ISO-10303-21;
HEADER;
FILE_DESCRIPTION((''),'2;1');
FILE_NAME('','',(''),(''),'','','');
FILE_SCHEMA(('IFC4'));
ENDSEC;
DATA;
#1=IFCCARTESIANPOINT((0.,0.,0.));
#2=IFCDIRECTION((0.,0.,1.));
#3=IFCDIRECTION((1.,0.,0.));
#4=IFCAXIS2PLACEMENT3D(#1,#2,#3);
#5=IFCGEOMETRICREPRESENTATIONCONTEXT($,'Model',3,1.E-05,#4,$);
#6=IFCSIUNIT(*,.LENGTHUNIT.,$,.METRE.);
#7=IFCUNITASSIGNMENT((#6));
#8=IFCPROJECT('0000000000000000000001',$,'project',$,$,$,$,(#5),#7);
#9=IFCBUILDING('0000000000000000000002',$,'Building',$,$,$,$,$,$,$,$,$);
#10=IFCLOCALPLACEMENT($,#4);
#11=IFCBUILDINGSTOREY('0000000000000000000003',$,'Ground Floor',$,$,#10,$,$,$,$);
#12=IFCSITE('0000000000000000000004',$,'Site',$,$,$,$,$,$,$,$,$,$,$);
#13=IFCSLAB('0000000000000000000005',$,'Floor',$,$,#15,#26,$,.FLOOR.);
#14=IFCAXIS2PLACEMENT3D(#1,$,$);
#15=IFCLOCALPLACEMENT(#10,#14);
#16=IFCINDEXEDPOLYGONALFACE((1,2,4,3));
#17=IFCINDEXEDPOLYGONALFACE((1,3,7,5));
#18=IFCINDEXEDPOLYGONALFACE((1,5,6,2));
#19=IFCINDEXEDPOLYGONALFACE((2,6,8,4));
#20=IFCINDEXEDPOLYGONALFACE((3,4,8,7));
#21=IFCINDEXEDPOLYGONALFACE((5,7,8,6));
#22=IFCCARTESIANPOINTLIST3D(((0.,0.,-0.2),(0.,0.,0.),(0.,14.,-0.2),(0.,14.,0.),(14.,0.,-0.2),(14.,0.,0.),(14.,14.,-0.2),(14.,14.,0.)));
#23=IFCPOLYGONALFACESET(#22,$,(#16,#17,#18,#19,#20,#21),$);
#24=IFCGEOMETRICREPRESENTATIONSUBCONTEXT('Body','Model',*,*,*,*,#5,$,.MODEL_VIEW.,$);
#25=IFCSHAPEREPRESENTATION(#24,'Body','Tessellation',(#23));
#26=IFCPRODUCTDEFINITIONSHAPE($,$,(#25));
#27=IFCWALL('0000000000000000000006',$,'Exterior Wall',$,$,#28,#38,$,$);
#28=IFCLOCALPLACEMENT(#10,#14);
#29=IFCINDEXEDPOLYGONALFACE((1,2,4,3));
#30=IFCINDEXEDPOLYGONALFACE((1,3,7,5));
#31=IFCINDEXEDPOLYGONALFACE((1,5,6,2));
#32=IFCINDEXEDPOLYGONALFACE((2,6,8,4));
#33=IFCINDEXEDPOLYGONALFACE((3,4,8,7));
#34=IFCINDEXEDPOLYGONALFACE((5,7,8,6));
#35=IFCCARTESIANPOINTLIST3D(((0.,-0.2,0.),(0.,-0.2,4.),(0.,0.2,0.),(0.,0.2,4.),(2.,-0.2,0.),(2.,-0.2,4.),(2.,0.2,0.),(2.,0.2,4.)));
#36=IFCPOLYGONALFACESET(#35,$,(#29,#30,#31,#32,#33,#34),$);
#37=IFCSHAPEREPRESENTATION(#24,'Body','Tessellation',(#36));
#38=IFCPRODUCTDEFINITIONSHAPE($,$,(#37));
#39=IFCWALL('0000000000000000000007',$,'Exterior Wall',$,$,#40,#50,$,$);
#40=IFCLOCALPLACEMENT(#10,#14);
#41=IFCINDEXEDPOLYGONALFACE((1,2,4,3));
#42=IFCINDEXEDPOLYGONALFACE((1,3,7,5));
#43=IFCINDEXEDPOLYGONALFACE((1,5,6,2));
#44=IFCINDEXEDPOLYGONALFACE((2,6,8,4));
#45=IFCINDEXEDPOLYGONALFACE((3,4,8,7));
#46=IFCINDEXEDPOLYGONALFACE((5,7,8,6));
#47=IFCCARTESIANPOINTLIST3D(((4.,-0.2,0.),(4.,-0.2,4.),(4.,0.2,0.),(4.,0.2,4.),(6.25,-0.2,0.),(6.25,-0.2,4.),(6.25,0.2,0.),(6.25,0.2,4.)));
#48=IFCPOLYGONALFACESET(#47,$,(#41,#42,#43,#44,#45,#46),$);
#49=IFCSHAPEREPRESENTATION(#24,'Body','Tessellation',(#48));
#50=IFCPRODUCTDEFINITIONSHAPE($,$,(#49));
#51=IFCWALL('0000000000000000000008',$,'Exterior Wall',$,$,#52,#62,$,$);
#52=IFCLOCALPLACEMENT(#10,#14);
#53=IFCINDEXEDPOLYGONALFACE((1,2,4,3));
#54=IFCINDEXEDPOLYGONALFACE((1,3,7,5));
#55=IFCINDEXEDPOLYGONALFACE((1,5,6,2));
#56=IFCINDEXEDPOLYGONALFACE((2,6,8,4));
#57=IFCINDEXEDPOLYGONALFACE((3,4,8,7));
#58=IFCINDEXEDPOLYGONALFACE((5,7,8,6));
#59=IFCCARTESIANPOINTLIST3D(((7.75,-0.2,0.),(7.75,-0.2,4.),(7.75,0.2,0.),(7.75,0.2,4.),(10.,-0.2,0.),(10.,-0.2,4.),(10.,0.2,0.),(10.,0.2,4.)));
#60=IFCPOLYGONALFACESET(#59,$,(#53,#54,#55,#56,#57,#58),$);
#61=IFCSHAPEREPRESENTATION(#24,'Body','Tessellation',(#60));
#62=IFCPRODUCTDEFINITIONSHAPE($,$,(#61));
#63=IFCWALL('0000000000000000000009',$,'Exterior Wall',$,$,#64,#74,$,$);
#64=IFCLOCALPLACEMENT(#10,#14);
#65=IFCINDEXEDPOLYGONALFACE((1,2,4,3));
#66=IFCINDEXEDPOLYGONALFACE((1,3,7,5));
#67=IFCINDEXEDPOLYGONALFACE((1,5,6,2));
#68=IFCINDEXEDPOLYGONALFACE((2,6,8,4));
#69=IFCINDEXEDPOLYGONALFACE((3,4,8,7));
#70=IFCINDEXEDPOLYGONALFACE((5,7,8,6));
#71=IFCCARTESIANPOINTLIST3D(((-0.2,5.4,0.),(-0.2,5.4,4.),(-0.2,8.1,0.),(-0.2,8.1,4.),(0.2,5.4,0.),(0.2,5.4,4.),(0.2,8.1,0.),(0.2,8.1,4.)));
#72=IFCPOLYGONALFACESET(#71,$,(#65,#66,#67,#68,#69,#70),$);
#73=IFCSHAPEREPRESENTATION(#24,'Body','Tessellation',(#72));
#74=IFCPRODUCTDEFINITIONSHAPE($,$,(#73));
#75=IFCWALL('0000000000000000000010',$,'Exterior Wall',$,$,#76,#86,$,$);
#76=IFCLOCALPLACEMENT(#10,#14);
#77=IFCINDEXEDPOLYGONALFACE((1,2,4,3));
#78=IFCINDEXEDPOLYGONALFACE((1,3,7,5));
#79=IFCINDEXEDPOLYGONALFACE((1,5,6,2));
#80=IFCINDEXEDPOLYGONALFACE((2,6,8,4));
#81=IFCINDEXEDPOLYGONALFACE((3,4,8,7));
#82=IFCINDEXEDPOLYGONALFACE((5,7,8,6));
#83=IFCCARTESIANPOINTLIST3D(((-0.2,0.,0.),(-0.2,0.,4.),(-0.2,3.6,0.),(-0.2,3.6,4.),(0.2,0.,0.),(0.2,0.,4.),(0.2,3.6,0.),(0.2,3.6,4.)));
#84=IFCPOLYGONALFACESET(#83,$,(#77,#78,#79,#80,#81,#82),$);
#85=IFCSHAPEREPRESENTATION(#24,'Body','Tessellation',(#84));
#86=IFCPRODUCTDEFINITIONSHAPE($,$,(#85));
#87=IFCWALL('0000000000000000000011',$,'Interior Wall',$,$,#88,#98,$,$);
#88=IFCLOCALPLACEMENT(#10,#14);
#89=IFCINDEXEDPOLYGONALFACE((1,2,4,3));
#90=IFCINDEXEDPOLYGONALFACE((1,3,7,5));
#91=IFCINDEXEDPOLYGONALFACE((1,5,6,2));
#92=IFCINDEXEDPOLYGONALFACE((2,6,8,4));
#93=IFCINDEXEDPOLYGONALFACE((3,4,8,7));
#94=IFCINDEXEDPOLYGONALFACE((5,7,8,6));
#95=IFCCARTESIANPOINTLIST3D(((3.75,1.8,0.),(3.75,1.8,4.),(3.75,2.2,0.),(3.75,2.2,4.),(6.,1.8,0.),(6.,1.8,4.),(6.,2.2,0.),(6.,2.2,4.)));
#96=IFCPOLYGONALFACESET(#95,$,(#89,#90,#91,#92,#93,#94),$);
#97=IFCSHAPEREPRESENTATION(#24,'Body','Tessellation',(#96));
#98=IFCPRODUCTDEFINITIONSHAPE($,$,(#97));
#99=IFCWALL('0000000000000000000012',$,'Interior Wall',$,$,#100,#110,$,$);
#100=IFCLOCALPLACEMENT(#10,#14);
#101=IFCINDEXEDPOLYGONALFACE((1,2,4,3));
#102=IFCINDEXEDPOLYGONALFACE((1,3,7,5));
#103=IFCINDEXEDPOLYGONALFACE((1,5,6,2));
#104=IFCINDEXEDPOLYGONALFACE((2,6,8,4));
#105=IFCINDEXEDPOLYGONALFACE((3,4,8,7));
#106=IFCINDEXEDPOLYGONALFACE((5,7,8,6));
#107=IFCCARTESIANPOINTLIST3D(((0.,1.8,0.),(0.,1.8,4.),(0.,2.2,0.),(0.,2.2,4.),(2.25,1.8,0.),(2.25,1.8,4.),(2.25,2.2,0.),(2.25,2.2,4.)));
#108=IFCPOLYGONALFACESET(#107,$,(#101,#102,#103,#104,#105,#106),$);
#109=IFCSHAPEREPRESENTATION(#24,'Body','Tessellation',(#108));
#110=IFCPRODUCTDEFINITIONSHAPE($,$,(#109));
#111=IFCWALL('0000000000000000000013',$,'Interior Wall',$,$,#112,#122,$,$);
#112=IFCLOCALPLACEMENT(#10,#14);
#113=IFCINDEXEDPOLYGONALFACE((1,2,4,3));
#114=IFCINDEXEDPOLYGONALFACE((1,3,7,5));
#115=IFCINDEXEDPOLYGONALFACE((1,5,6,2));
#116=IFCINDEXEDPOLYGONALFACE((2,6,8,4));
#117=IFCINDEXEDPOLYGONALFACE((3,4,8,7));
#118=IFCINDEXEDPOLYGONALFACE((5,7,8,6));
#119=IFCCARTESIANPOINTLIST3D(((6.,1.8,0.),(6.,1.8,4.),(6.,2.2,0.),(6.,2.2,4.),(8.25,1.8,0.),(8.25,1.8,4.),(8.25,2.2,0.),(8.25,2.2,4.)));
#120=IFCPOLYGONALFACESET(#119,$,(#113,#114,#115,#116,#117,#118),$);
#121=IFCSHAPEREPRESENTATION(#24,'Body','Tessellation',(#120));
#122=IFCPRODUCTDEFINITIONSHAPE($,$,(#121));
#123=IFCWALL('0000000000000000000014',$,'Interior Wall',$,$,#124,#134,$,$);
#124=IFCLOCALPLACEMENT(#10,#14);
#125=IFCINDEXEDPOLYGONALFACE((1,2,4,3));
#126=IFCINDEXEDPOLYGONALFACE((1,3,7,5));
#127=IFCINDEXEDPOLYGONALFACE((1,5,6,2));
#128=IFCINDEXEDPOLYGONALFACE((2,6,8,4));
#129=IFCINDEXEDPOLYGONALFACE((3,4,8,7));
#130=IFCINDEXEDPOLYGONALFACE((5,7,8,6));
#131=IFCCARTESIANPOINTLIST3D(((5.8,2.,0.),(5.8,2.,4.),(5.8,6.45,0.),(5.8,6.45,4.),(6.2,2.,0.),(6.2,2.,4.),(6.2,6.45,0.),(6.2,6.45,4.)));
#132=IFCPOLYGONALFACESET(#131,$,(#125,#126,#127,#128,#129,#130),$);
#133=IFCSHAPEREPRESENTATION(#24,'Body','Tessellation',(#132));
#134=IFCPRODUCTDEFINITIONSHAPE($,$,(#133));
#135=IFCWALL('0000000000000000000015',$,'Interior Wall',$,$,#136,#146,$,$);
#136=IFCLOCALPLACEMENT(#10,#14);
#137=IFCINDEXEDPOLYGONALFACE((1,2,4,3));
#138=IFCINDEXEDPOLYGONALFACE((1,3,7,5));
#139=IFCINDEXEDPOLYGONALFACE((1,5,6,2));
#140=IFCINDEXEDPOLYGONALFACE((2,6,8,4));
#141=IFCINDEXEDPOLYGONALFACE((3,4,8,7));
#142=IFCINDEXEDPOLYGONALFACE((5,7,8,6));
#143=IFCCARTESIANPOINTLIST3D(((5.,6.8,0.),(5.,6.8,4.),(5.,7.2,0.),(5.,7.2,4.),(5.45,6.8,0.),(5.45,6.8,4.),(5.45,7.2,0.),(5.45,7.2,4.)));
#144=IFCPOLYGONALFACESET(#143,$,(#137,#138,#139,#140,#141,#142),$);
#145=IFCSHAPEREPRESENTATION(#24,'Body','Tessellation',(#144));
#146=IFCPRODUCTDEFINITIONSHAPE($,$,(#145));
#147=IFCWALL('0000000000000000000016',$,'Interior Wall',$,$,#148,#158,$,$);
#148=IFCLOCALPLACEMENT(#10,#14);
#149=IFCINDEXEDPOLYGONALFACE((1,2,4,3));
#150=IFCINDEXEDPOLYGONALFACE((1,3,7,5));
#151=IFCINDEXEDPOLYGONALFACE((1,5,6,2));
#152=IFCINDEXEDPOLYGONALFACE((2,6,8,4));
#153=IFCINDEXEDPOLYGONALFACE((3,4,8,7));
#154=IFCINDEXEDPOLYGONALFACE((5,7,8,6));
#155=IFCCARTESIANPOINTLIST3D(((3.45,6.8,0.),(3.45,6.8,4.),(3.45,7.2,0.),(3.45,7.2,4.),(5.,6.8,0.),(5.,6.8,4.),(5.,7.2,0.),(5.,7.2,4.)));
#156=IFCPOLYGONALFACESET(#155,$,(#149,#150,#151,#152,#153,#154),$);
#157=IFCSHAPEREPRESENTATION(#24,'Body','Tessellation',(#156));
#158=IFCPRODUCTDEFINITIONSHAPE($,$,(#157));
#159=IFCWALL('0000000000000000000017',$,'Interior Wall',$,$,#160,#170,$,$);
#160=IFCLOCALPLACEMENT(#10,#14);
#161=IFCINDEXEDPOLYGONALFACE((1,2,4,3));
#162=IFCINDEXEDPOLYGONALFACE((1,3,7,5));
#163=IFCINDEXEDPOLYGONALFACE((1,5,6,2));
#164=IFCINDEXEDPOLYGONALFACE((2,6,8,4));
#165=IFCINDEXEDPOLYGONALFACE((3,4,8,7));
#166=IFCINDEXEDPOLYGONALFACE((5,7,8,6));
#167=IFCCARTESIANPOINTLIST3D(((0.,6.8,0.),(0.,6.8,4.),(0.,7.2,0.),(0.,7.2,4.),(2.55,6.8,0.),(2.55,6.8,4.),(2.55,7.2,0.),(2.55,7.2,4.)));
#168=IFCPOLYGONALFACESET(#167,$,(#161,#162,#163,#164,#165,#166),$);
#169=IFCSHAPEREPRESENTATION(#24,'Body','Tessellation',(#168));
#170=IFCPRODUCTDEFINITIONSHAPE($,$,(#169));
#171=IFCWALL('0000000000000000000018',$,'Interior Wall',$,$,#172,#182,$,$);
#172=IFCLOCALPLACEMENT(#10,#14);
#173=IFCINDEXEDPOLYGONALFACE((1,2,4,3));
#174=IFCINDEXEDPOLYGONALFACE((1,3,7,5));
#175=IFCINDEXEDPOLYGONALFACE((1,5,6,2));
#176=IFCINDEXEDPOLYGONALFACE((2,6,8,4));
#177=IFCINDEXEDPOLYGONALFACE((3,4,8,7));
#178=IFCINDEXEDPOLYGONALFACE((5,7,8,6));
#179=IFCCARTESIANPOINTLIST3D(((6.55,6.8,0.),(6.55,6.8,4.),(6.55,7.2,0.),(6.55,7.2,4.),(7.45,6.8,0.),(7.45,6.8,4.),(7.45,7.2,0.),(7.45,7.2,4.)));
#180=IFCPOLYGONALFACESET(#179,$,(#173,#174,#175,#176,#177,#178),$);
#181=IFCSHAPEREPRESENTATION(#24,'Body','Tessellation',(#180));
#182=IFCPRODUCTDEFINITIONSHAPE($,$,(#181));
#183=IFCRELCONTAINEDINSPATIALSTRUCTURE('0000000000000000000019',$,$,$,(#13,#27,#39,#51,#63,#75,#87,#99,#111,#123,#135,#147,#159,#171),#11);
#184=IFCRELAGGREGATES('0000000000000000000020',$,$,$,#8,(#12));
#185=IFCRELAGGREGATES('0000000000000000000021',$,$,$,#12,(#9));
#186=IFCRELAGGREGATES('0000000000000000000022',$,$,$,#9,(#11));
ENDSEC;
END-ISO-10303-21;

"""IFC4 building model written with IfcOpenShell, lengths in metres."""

from ifc_helpers import new_model, si_unit, frame, origin_with_axes, place, context, subcontext, project, spatial, indexed_curve, outline, extrude, element, save


model = new_model("IFC4")

# Units and contexts
model_context = context("Model", 3, precision=1e-05, world=origin_with_axes())
body_context = subcontext(model_context, "Body", "Model", "MODEL_VIEW")
ifc_project = project(units=[si_unit("LENGTHUNIT", "METRE")], contexts=[model_context])

# Site, building, storey
site = spatial("IfcSite", under=ifc_project, Name="Site")
building = spatial("IfcBuilding", under=site, Name="Building")
storey_placement = place(None, origin_with_axes())
storey = spatial("IfcBuildingStorey", under=building, at=storey_placement, Name="Ground Floor")

# Slab
slab_placement = place(storey_placement, frame((0.0, 0.0, -0.2), z_axis=(0.0, 0.0, 1.0), x_axis=(1.0, 0.0, 0.0)))
element("IfcSlab", 1, at=slab_placement, inside=storey, Name="Floor", PredefinedType="FLOOR", context=body_context, shape_type="SweptSolid", body=[
    extrude(outline(indexed_curve([(0.0, 0.0), (14.0, 0.0), (14.0, 14.0), (0.0, 14.0)])), None, (0.0, 0.0, 1.0), 0.2),
])

# Walls
wall_1_placement = place(storey_placement, origin_with_axes())
element("IfcWall", 2, at=wall_1_placement, inside=storey, Name="Exterior Wall", context=body_context, shape_type="SweptSolid", body=[
    extrude(outline(indexed_curve([(0.0, 0.0), (0.0, 0.4), (2.0, 0.4), (2.0, 0.0), (0.0, 0.0)], self_intersect=False)), frame((0.0, -0.2, 0.0), z_axis=(0.0, 0.0, 1.0), x_axis=(1.0, 0.0, 0.0)), (0.0, 0.0, 1.0), 4.0),
])
for number, where, z_axis, x_axis, name in (
    (3, (4.0, 0.0, 0.0), (0.0, 0.0, 1.0), (1.0, 0.0, 0.0), "Exterior Wall"),
    (4, (7.75, 0.0, 0.0), (0.0, 0.0, 1.0), (1.0, 0.0, 0.0), "Exterior Wall"),
):
    element("IfcWall", number, at=place(storey_placement, frame(where, z_axis=z_axis, x_axis=x_axis)), inside=storey, Name=name, context=body_context, shape_type="SweptSolid", body=[
        extrude(outline(indexed_curve([(0.0, 0.0), (0.0, 0.4), (2.25, 0.4), (2.25, 0.0), (0.0, 0.0)], self_intersect=False)), frame((0.0, -0.2, 0.0), z_axis=(0.0, 0.0, 1.0), x_axis=(1.0, 0.0, 0.0)), (0.0, 0.0, 1.0), 4.0),
    ])
wall_2_placement = place(storey_placement, frame((0.0, 8.1, 0.0), z_axis=(0.0, 0.0, 1.0), x_axis=(0.0, -1.0, 0.0)))
element("IfcWall", 5, at=wall_2_placement, inside=storey, Name="Exterior Wall", context=body_context, shape_type="SweptSolid", body=[
    extrude(outline(indexed_curve([(0.0, 0.0), (0.0, 0.4), (2.7, 0.4), (2.7, 0.0), (0.0, 0.0)], self_intersect=False)), frame((0.0, -0.2, 0.0), z_axis=(0.0, 0.0, 1.0), x_axis=(1.0, 0.0, 0.0)), (0.0, 0.0, 1.0), 4.0),
])
wall_3_placement = place(storey_placement, frame((0.0, 3.6, 0.0), z_axis=(0.0, 0.0, 1.0), x_axis=(0.0, -1.0, 0.0)))
element("IfcWall", 6, at=wall_3_placement, inside=storey, Name="Exterior Wall", context=body_context, shape_type="SweptSolid", body=[
    extrude(outline(indexed_curve([(0.0, 0.0), (0.0, 0.4), (3.6, 0.4), (3.6, 0.0), (0.0, 0.0)], self_intersect=False)), frame((0.0, -0.2, 0.0), z_axis=(0.0, 0.0, 1.0), x_axis=(1.0, 0.0, 0.0)), (0.0, 0.0, 1.0), 4.0),
])
for number, where, z_axis, x_axis, name in (
    (7, (6.0, 2.0, 0.0), (0.0, 0.0, 1.0), (-1.0, 0.0, 0.0), "Interior Wall"),
    (8, (2.25, 2.0, 0.0), (0.0, 0.0, 1.0), (-1.0, 0.0, 0.0), "Interior Wall"),
    (9, (8.25, 2.0, 0.0), (0.0, 0.0, 1.0), (-1.0, 0.0, 0.0), "Interior Wall"),
):
    element("IfcWall", number, at=place(storey_placement, frame(where, z_axis=z_axis, x_axis=x_axis)), inside=storey, Name=name, context=body_context, shape_type="SweptSolid", body=[
        extrude(outline(indexed_curve([(0.0, 0.0), (0.0, 0.4), (2.25, 0.4), (2.25, 0.0), (0.0, 0.0)], self_intersect=False)), frame((0.0, -0.2, 0.0), z_axis=(0.0, 0.0, 1.0), x_axis=(1.0, 0.0, 0.0)), (0.0, 0.0, 1.0), 4.0),
    ])
wall_4_placement = place(storey_placement, frame((6.0, 2.0, 0.0), z_axis=(0.0, 0.0, 1.0), x_axis=(0.0, 1.0, 0.0)))
element("IfcWall", 10, at=wall_4_placement, inside=storey, Name="Interior Wall", context=body_context, shape_type="SweptSolid", body=[
    extrude(outline(indexed_curve([(0.0, 0.0), (0.0, 0.4), (4.45, 0.4), (4.45, 0.0), (0.0, 0.0)], self_intersect=False)), frame((0.0, -0.2, 0.0), z_axis=(0.0, 0.0, 1.0), x_axis=(1.0, 0.0, 0.0)), (0.0, 0.0, 1.0), 4.0),
])
wall_5_placement = place(storey_placement, frame((5.45, 7.0, 0.0), z_axis=(0.0, 0.0, 1.0), x_axis=(-1.0, 0.0, 0.0)))
element("IfcWall", 11, at=wall_5_placement, inside=storey, Name="Interior Wall", context=body_context, shape_type="SweptSolid", body=[
    extrude(outline(indexed_curve([(0.0, 0.0), (0.0, 0.4), (0.45, 0.4), (0.45, 0.0), (0.0, 0.0)], self_intersect=False)), frame((0.0, -0.2, 0.0), z_axis=(0.0, 0.0, 1.0), x_axis=(1.0, 0.0, 0.0)), (0.0, 0.0, 1.0), 4.0),
])
wall_6_placement = place(storey_placement, frame((5.0, 7.0, 0.0), z_axis=(0.0, 0.0, 1.0), x_axis=(-1.0, 0.0, 0.0)))
element("IfcWall", 12, at=wall_6_placement, inside=storey, Name="Interior Wall", context=body_context, shape_type="SweptSolid", body=[
    extrude(outline(indexed_curve([(0.0, 0.0), (0.0, 0.4), (1.55, 0.4), (1.55, 0.0), (0.0, 0.0)], self_intersect=False)), frame((0.0, -0.2, 0.0), z_axis=(0.0, 0.0, 1.0), x_axis=(1.0, 0.0, 0.0)), (0.0, 0.0, 1.0), 4.0),
])
wall_7_placement = place(storey_placement, frame((2.55, 7.0, 0.0), z_axis=(0.0, 0.0, 1.0), x_axis=(-1.0, 0.0, 0.0)))
element("IfcWall", 13, at=wall_7_placement, inside=storey, Name="Interior Wall", context=body_context, shape_type="SweptSolid", body=[
    extrude(outline(indexed_curve([(0.0, 0.0), (0.0, 0.4), (2.55, 0.4), (2.55, 0.0), (0.0, 0.0)], self_intersect=False)), frame((0.0, -0.2, 0.0), z_axis=(0.0, 0.0, 1.0), x_axis=(1.0, 0.0, 0.0)), (0.0, 0.0, 1.0), 4.0),
])
wall_8_placement = place(storey_placement, frame((7.45, 7.0, 0.0), z_axis=(0.0, 0.0, 1.0), x_axis=(-1.0, 0.0, 0.0)))
element("IfcWall", 14, at=wall_8_placement, inside=storey, Name="Interior Wall", context=body_context, shape_type="SweptSolid", body=[
    extrude(outline(indexed_curve([(0.0, 0.0), (0.0, 0.4), (0.9, 0.4), (0.9, 0.0), (0.0, 0.0)], self_intersect=False)), frame((0.0, -0.2, 0.0), z_axis=(0.0, 0.0, 1.0), x_axis=(1.0, 0.0, 0.0)), (0.0, 0.0, 1.0), 4.0),
])

save(model, "model.ifc")
